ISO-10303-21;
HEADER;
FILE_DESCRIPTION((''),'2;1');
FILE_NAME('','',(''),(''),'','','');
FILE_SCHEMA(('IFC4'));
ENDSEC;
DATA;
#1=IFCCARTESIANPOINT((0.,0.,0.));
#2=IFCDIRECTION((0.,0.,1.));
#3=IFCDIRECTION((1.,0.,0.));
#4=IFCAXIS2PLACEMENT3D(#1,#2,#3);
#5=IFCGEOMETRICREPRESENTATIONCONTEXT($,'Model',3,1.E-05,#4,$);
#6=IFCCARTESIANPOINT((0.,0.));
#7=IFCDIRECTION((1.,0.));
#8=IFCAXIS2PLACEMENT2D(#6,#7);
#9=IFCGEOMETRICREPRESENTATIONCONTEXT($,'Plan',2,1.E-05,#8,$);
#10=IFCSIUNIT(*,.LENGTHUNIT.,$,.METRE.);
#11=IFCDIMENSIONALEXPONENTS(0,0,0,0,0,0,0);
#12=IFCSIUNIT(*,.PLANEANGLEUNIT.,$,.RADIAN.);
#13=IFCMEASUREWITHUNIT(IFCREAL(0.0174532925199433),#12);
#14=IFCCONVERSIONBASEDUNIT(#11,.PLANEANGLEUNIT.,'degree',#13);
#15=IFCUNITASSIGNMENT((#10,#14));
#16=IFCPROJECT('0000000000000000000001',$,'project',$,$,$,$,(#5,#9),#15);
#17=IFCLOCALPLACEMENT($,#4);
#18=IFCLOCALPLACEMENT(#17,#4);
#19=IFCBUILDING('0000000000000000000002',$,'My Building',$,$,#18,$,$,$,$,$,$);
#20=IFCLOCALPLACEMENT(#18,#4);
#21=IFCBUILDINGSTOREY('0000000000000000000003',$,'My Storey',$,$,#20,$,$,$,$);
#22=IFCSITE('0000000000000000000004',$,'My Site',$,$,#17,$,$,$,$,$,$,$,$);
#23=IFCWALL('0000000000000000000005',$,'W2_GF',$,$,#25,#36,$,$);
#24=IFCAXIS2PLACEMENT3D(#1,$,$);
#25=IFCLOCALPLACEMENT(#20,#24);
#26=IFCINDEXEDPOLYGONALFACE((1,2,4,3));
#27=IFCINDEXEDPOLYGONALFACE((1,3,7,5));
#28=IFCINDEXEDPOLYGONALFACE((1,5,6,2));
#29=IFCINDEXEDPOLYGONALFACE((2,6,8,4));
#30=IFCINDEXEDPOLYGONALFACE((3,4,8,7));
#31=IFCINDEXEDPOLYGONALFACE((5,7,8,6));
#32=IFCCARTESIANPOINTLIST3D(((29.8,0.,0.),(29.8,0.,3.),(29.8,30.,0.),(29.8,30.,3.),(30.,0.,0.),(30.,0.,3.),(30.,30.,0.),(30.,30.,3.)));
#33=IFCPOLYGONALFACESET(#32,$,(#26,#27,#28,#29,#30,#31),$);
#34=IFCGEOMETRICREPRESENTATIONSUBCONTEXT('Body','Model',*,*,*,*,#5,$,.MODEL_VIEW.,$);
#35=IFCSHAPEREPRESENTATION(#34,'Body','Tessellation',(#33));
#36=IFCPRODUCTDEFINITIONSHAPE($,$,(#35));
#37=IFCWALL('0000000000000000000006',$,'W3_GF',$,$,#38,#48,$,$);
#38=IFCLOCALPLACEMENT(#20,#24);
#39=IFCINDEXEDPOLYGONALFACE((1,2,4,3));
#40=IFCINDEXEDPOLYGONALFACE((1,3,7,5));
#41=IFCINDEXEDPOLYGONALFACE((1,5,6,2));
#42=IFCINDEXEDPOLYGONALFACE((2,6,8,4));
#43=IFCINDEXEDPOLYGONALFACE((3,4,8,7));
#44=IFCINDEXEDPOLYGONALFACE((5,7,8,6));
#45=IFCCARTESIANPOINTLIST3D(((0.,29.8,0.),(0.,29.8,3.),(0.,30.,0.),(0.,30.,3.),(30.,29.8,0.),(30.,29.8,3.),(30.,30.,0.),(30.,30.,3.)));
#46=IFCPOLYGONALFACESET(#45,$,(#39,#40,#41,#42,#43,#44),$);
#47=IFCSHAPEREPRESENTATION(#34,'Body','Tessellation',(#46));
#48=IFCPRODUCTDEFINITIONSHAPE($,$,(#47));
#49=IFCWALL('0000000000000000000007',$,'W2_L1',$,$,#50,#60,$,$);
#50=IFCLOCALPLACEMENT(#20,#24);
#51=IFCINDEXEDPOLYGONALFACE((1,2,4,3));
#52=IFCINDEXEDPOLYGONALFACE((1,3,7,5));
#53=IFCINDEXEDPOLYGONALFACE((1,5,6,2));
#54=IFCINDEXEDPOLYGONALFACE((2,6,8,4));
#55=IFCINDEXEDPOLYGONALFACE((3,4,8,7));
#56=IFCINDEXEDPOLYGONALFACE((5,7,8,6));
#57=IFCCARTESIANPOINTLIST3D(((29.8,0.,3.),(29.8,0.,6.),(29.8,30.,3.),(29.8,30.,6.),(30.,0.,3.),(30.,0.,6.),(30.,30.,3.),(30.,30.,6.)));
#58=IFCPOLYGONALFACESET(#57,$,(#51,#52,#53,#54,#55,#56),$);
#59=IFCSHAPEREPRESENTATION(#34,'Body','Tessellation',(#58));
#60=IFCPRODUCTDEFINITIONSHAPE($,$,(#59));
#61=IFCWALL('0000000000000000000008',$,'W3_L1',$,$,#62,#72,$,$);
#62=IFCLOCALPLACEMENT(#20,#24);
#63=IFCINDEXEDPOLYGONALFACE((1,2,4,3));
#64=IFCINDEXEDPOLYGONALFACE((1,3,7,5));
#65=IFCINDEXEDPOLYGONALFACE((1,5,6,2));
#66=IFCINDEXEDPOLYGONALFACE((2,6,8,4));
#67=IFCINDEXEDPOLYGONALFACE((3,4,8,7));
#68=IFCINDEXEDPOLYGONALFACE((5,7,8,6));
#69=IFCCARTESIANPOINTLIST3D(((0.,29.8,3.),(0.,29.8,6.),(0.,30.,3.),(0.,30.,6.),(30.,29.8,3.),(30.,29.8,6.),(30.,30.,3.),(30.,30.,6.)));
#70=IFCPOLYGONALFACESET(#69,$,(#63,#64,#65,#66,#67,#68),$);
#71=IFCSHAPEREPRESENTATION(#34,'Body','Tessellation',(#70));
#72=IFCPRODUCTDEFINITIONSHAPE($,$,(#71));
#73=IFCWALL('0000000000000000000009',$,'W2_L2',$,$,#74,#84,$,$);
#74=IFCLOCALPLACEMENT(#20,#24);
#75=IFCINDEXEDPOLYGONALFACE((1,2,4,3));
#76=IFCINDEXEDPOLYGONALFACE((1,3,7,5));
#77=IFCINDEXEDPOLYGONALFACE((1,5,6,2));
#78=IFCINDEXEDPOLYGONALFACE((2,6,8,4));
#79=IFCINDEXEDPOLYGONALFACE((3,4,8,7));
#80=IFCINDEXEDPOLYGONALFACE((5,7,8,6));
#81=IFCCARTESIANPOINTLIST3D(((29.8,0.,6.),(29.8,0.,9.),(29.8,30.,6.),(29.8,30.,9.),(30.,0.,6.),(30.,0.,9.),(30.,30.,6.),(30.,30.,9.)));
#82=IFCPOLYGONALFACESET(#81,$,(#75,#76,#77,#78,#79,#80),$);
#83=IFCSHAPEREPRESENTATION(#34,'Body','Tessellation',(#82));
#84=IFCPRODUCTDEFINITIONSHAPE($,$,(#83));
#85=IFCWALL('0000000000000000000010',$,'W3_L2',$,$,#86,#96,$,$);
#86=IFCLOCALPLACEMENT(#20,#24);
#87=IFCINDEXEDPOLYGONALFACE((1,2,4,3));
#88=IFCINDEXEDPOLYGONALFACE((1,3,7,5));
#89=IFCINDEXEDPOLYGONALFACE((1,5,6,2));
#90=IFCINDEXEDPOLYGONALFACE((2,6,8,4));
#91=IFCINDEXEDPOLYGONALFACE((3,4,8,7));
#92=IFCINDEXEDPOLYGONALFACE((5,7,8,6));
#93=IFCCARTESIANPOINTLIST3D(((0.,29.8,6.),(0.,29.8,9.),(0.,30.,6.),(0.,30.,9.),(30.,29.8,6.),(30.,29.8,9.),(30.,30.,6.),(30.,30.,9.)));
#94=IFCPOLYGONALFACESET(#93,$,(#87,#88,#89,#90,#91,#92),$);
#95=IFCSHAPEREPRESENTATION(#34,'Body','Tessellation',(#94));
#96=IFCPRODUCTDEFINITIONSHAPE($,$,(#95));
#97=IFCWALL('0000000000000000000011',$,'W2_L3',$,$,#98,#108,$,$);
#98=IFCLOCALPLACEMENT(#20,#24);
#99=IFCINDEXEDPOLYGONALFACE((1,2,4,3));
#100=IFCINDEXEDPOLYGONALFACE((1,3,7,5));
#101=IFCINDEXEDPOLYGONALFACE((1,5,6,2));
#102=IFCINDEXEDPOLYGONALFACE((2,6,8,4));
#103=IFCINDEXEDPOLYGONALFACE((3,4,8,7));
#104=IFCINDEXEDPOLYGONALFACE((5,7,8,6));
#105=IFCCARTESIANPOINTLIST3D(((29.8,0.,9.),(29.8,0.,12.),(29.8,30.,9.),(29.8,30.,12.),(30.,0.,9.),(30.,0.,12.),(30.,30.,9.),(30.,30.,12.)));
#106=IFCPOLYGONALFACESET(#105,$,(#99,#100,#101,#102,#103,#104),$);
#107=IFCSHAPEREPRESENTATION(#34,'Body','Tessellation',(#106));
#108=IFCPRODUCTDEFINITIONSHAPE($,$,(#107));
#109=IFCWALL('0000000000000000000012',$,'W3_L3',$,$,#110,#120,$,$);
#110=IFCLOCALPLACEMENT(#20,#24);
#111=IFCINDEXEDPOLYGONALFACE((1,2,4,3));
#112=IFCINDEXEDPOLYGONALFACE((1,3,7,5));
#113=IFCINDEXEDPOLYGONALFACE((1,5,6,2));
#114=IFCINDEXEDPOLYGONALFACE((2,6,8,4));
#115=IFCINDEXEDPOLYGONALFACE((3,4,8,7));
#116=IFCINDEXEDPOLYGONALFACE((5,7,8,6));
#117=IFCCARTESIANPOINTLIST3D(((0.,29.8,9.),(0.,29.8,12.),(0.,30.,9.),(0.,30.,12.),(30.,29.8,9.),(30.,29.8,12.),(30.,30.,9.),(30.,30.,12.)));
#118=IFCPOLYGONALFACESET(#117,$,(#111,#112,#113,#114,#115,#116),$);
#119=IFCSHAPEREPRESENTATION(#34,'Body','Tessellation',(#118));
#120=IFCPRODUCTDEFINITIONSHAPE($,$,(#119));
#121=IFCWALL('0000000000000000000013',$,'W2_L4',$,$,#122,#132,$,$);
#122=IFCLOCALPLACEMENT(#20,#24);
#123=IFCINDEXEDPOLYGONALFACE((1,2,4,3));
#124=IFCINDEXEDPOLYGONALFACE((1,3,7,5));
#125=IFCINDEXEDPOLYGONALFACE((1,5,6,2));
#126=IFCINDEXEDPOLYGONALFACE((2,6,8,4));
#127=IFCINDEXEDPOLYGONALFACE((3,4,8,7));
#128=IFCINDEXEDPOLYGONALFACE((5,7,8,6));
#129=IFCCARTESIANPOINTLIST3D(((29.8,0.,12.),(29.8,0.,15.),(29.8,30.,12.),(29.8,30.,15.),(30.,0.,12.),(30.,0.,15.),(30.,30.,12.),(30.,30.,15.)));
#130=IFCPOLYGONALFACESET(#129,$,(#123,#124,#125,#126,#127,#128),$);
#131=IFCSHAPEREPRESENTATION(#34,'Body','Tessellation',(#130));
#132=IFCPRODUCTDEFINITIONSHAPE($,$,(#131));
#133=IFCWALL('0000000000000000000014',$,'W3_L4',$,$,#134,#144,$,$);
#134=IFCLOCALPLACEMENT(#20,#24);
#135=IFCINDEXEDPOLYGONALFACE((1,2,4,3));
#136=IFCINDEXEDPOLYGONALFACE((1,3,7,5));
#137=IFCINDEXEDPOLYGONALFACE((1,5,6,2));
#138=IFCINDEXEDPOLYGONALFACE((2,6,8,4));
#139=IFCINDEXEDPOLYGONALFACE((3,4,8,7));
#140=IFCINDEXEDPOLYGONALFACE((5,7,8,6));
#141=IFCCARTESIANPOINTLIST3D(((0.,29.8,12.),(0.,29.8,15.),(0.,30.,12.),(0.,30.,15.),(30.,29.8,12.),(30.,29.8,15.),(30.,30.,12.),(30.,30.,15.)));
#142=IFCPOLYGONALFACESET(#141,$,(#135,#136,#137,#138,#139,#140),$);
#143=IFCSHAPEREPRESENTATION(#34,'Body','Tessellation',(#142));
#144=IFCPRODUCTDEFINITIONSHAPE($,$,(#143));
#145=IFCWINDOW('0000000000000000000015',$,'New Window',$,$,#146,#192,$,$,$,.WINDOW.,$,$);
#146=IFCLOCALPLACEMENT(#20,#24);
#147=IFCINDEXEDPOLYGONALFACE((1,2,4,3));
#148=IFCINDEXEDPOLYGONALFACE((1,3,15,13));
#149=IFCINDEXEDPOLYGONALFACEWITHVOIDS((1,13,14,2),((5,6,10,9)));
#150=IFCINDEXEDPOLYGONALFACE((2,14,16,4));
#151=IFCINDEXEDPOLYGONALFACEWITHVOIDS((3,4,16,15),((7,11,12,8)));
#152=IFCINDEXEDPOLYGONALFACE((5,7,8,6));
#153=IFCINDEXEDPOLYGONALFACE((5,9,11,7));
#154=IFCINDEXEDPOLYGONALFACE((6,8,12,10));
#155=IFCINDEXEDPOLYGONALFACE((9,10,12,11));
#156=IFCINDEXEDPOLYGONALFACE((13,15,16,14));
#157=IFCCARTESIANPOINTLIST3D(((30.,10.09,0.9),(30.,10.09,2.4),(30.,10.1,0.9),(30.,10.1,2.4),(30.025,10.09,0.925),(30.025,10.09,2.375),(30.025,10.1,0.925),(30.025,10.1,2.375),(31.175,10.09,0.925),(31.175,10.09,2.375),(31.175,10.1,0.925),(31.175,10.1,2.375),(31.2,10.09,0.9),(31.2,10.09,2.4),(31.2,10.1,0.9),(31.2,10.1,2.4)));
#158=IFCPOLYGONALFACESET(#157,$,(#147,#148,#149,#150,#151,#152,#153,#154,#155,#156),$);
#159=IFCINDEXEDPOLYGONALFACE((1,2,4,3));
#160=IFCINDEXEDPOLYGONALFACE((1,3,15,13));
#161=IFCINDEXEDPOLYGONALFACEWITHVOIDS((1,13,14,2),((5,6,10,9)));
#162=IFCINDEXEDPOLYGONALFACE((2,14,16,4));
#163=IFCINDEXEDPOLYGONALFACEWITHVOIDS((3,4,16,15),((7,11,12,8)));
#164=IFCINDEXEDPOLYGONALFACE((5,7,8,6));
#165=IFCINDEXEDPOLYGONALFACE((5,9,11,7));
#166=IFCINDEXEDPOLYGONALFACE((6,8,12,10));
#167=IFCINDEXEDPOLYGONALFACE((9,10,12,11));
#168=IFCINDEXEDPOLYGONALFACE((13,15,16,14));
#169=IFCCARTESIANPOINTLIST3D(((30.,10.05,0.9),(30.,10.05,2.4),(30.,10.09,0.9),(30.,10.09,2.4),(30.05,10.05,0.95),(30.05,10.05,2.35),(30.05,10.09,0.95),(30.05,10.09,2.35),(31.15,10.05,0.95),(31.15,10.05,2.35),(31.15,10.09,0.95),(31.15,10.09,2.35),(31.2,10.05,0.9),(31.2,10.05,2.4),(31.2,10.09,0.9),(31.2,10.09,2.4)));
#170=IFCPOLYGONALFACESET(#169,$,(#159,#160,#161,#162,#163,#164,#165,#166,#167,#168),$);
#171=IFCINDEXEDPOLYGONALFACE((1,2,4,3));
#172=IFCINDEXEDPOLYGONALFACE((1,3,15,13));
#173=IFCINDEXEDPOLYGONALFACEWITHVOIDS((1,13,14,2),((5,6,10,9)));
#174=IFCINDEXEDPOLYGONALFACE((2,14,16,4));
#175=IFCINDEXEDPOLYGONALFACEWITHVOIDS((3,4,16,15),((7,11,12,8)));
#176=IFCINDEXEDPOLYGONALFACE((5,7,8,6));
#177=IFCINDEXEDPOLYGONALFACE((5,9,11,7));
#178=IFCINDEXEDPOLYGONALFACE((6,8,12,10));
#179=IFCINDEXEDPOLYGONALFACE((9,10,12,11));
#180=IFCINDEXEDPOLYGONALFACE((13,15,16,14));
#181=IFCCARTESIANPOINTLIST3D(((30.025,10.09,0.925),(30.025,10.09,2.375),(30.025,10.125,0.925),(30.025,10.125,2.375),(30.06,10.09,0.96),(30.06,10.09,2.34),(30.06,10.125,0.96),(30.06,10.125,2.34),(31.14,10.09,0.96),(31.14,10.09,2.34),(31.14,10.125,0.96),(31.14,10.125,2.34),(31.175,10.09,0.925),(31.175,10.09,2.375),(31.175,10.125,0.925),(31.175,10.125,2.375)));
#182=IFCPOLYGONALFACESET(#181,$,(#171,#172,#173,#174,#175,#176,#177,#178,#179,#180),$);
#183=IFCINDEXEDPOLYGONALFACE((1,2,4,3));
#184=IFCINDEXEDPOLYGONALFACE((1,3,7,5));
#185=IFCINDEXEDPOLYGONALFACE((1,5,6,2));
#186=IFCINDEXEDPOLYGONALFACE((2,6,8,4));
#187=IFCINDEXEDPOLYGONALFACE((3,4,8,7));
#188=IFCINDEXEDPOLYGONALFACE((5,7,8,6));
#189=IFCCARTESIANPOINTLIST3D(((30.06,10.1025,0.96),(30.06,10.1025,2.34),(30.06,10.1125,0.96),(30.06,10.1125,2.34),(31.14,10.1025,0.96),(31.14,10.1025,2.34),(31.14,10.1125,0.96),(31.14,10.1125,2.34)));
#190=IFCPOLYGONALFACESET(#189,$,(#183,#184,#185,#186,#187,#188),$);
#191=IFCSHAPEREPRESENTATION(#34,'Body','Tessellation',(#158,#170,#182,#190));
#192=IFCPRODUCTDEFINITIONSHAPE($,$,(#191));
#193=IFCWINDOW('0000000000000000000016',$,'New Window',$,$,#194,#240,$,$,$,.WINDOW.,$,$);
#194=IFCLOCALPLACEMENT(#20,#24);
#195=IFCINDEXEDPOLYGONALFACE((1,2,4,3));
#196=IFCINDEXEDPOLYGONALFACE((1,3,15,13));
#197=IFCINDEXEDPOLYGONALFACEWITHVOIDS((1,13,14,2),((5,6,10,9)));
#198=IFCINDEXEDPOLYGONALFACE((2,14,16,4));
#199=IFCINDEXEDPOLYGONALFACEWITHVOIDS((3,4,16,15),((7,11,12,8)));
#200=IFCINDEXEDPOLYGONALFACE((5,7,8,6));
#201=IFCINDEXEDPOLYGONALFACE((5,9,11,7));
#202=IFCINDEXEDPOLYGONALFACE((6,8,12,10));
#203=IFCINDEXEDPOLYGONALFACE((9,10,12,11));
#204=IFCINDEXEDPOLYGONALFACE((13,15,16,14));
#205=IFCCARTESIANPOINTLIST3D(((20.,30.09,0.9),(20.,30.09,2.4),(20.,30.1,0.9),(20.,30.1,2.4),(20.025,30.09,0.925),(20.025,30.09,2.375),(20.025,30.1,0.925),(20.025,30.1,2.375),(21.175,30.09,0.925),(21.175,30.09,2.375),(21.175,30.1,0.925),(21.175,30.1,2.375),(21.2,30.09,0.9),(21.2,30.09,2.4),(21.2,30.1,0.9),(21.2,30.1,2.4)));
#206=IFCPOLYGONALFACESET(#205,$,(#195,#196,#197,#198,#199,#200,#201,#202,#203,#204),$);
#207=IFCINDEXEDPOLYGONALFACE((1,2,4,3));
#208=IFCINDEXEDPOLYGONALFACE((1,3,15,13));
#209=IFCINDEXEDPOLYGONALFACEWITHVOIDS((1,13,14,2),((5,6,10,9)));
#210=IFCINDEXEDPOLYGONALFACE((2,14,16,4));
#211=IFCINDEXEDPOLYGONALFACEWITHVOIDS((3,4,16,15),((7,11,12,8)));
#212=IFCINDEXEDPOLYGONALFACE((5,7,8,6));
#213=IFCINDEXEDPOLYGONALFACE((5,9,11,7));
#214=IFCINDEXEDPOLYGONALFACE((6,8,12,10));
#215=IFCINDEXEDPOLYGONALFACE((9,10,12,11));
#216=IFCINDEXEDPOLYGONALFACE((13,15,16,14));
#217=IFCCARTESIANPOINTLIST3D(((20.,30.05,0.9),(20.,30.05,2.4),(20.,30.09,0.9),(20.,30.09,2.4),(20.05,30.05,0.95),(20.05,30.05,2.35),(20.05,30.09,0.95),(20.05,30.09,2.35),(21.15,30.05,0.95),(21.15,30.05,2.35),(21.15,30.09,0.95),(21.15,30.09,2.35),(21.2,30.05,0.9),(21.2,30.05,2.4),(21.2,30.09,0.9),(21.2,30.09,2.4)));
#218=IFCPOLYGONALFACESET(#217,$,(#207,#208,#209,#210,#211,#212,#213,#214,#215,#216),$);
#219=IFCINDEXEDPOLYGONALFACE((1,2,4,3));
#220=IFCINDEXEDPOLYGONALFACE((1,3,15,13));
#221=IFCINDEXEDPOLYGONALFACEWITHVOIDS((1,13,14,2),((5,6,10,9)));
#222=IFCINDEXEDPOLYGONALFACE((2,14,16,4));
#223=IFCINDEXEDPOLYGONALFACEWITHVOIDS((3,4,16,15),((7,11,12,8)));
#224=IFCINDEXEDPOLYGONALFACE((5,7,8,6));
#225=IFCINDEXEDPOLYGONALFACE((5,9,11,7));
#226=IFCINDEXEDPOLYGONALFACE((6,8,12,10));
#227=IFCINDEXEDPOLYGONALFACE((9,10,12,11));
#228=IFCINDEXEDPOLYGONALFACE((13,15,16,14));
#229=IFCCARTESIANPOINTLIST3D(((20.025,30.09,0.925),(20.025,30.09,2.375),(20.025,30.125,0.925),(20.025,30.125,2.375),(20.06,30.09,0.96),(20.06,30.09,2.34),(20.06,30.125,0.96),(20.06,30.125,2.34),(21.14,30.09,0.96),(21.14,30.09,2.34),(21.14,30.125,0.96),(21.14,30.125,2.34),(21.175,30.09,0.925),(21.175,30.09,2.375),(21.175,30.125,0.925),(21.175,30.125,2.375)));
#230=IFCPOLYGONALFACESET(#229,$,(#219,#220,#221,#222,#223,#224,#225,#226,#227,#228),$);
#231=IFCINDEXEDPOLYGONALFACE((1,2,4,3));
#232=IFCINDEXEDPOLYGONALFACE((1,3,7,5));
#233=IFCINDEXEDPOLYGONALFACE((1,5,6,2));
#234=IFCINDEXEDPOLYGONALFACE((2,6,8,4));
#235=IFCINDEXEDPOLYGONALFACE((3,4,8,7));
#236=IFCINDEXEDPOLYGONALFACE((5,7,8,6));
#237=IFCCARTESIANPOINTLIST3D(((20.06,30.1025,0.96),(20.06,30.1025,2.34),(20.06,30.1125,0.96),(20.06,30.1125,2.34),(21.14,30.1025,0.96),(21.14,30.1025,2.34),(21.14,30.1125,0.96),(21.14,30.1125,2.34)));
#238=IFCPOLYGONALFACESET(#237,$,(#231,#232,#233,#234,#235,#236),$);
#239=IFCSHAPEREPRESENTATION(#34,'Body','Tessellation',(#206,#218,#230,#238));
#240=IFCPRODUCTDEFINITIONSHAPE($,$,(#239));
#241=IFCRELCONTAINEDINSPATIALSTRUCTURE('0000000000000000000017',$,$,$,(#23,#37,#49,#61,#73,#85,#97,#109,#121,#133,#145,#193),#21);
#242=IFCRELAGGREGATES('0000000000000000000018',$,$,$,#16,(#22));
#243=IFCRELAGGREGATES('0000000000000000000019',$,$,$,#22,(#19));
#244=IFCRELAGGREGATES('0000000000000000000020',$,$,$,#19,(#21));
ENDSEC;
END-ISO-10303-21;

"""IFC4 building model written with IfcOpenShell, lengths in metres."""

from ifc_helpers import new_model, entity, si_unit, converted_unit, frame, origin_with_axes, origin_2d_with_axis, place, context, subcontext, project, spatial, line, indexed_curve, outline, extrude, element, save


model = new_model("IFC4")

# Units and contexts
model_context = context("Model", 3, precision=1e-05, world=origin_with_axes())
plan_context = context("Plan", 2, precision=1e-05, world=origin_2d_with_axis())
body_context = subcontext(model_context, "Body", "Model", "MODEL_VIEW")
ifc_project = project(units=[si_unit("LENGTHUNIT", "METRE"), converted_unit("PLANEANGLEUNIT", "degree", entity("IfcReal", 0.0174532925199433), si_unit("PLANEANGLEUNIT", "RADIAN"), dimensions=[0, 0, 0, 0, 0, 0, 0])], contexts=[model_context, plan_context])

# Site, building, storey
site_placement = place(None, origin_with_axes())
site = spatial("IfcSite", under=ifc_project, at=site_placement, Name="My Site")
building_placement = place(site_placement, origin_with_axes())
building = spatial("IfcBuilding", under=site, at=building_placement, Name="My Building")
storey_placement = place(building_placement, origin_with_axes())
storey = spatial("IfcBuildingStorey", under=building, at=storey_placement, Name="My Storey")

# Walls
for number, where, z_axis, x_axis, name in (
    (1, (30.0, 0.0, 0.0), (0.0, 0.0, 1.0), (0.0, 1.0, 0.0), "W2_GF"),
    (2, (30.0, 30.0, 0.0), (0.0, 0.0, 1.0), (-1.0, 0.0, 0.0), "W3_GF"),
    (3, (30.0, 0.0, 3.0), (0.0, 0.0, 1.0), (0.0, 1.0, 0.0), "W2_L1"),
    (4, (30.0, 30.0, 3.0), (0.0, 0.0, 1.0), (-1.0, 0.0, 0.0), "W3_L1"),
    (5, (30.0, 0.0, 6.0), (0.0, 0.0, 1.0), (0.0, 1.0, 0.0), "W2_L2"),
    (6, (30.0, 30.0, 6.0), (0.0, 0.0, 1.0), (-1.0, 0.0, 0.0), "W3_L2"),
    (7, (30.0, 0.0, 9.0), (0.0, 0.0, 1.0), (0.0, 1.0, 0.0), "W2_L3"),
    (8, (30.0, 30.0, 9.0), (0.0, 0.0, 1.0), (-1.0, 0.0, 0.0), "W3_L3"),
    (9, (30.0, 0.0, 12.0), (0.0, 0.0, 1.0), (0.0, 1.0, 0.0), "W2_L4"),
    (10, (30.0, 30.0, 12.0), (0.0, 0.0, 1.0), (-1.0, 0.0, 0.0), "W3_L4"),
):
    element("IfcWall", number, at=place(storey_placement, frame(where, z_axis=z_axis, x_axis=x_axis)), inside=storey, Name=name, context=body_context, shape_type="SweptSolid", body=[
        extrude(outline(indexed_curve([(0.0, 0.0), (0.0, 0.2), (30.0, 0.2), (30.0, 0.0), (0.0, 0.0)], self_intersect=False)), origin_with_axes(), (0.0, 0.0, 1.0), 3.0),
    ])

# Windows
for number, where, z_axis, x_axis, name in (
    (11, (30.0, 10.0, 0.9), (0.0, 0.0, 1.0), (1.0, 0.0, 0.0), "New Window"),
    (12, (20.0, 30.0, 0.9), (0.0, 0.0, 1.0), (1.0, 0.0, 0.0), "New Window"),
):
    element("IfcWindow", number, at=place(storey_placement, frame(where, z_axis=z_axis, x_axis=x_axis)), inside=storey, Name=name, PredefinedType="WINDOW", context=body_context, shape_type="SweptSolid", body=[
        extrude(outline(indexed_curve([(0.0, 0.0), (1.2, 0.0), (1.2, 1.5), (0.0, 1.5)], segments=[line(1, 2, 3, 4, 1)]), holes=[indexed_curve([(0.025, 0.025), (1.175, 0.025), (1.175, 1.475), (0.025, 1.475)], segments=[line(1, 2, 3, 4, 1)])]), frame((0.0, 0.09, 0.0), z_axis=(0.0, -1.0, 0.0), x_axis=(1.0, 0.0, 0.0)), (0.0, 0.0, -1.0), 0.01),
        extrude(outline(indexed_curve([(0.0, 0.0), (1.2, 0.0), (1.2, 1.5), (0.0, 1.5)], segments=[line(1, 2, 3, 4, 1)]), holes=[indexed_curve([(0.05, 0.05), (1.15, 0.05), (1.15, 1.45), (0.05, 1.45)], segments=[line(1, 2, 3, 4, 1)])]), frame((0.0, 0.05, 0.0), z_axis=(0.0, -1.0, 0.0), x_axis=(1.0, 0.0, 0.0)), (0.0, 0.0, -1.0), 0.04),
        extrude(outline(indexed_curve([(0.0, 0.0), (1.15, 0.0), (1.15, 1.45), (0.0, 1.45)], segments=[line(1, 2, 3, 4, 1)]), holes=[indexed_curve([(0.035, 0.035), (1.115, 0.035), (1.115, 1.415), (0.035, 1.415)], segments=[line(1, 2, 3, 4, 1)])]), frame((0.025, 0.09, 0.025), z_axis=(0.0, -1.0, 0.0), x_axis=(1.0, 0.0, 0.0)), (0.0, 0.0, -1.0), 0.035),
        extrude(outline(indexed_curve([(0.035, 0.035), (1.115, 0.035), (1.115, 1.415), (0.035, 1.415)], segments=[line(1, 2, 3, 4, 1)])), frame((0.025, 0.1025, 0.025), z_axis=(0.0, -1.0, 0.0), x_axis=(1.0, 0.0, 0.0)), (0.0, 0.0, -1.0), 0.01),
    ])

save(model, "model.ifc")
